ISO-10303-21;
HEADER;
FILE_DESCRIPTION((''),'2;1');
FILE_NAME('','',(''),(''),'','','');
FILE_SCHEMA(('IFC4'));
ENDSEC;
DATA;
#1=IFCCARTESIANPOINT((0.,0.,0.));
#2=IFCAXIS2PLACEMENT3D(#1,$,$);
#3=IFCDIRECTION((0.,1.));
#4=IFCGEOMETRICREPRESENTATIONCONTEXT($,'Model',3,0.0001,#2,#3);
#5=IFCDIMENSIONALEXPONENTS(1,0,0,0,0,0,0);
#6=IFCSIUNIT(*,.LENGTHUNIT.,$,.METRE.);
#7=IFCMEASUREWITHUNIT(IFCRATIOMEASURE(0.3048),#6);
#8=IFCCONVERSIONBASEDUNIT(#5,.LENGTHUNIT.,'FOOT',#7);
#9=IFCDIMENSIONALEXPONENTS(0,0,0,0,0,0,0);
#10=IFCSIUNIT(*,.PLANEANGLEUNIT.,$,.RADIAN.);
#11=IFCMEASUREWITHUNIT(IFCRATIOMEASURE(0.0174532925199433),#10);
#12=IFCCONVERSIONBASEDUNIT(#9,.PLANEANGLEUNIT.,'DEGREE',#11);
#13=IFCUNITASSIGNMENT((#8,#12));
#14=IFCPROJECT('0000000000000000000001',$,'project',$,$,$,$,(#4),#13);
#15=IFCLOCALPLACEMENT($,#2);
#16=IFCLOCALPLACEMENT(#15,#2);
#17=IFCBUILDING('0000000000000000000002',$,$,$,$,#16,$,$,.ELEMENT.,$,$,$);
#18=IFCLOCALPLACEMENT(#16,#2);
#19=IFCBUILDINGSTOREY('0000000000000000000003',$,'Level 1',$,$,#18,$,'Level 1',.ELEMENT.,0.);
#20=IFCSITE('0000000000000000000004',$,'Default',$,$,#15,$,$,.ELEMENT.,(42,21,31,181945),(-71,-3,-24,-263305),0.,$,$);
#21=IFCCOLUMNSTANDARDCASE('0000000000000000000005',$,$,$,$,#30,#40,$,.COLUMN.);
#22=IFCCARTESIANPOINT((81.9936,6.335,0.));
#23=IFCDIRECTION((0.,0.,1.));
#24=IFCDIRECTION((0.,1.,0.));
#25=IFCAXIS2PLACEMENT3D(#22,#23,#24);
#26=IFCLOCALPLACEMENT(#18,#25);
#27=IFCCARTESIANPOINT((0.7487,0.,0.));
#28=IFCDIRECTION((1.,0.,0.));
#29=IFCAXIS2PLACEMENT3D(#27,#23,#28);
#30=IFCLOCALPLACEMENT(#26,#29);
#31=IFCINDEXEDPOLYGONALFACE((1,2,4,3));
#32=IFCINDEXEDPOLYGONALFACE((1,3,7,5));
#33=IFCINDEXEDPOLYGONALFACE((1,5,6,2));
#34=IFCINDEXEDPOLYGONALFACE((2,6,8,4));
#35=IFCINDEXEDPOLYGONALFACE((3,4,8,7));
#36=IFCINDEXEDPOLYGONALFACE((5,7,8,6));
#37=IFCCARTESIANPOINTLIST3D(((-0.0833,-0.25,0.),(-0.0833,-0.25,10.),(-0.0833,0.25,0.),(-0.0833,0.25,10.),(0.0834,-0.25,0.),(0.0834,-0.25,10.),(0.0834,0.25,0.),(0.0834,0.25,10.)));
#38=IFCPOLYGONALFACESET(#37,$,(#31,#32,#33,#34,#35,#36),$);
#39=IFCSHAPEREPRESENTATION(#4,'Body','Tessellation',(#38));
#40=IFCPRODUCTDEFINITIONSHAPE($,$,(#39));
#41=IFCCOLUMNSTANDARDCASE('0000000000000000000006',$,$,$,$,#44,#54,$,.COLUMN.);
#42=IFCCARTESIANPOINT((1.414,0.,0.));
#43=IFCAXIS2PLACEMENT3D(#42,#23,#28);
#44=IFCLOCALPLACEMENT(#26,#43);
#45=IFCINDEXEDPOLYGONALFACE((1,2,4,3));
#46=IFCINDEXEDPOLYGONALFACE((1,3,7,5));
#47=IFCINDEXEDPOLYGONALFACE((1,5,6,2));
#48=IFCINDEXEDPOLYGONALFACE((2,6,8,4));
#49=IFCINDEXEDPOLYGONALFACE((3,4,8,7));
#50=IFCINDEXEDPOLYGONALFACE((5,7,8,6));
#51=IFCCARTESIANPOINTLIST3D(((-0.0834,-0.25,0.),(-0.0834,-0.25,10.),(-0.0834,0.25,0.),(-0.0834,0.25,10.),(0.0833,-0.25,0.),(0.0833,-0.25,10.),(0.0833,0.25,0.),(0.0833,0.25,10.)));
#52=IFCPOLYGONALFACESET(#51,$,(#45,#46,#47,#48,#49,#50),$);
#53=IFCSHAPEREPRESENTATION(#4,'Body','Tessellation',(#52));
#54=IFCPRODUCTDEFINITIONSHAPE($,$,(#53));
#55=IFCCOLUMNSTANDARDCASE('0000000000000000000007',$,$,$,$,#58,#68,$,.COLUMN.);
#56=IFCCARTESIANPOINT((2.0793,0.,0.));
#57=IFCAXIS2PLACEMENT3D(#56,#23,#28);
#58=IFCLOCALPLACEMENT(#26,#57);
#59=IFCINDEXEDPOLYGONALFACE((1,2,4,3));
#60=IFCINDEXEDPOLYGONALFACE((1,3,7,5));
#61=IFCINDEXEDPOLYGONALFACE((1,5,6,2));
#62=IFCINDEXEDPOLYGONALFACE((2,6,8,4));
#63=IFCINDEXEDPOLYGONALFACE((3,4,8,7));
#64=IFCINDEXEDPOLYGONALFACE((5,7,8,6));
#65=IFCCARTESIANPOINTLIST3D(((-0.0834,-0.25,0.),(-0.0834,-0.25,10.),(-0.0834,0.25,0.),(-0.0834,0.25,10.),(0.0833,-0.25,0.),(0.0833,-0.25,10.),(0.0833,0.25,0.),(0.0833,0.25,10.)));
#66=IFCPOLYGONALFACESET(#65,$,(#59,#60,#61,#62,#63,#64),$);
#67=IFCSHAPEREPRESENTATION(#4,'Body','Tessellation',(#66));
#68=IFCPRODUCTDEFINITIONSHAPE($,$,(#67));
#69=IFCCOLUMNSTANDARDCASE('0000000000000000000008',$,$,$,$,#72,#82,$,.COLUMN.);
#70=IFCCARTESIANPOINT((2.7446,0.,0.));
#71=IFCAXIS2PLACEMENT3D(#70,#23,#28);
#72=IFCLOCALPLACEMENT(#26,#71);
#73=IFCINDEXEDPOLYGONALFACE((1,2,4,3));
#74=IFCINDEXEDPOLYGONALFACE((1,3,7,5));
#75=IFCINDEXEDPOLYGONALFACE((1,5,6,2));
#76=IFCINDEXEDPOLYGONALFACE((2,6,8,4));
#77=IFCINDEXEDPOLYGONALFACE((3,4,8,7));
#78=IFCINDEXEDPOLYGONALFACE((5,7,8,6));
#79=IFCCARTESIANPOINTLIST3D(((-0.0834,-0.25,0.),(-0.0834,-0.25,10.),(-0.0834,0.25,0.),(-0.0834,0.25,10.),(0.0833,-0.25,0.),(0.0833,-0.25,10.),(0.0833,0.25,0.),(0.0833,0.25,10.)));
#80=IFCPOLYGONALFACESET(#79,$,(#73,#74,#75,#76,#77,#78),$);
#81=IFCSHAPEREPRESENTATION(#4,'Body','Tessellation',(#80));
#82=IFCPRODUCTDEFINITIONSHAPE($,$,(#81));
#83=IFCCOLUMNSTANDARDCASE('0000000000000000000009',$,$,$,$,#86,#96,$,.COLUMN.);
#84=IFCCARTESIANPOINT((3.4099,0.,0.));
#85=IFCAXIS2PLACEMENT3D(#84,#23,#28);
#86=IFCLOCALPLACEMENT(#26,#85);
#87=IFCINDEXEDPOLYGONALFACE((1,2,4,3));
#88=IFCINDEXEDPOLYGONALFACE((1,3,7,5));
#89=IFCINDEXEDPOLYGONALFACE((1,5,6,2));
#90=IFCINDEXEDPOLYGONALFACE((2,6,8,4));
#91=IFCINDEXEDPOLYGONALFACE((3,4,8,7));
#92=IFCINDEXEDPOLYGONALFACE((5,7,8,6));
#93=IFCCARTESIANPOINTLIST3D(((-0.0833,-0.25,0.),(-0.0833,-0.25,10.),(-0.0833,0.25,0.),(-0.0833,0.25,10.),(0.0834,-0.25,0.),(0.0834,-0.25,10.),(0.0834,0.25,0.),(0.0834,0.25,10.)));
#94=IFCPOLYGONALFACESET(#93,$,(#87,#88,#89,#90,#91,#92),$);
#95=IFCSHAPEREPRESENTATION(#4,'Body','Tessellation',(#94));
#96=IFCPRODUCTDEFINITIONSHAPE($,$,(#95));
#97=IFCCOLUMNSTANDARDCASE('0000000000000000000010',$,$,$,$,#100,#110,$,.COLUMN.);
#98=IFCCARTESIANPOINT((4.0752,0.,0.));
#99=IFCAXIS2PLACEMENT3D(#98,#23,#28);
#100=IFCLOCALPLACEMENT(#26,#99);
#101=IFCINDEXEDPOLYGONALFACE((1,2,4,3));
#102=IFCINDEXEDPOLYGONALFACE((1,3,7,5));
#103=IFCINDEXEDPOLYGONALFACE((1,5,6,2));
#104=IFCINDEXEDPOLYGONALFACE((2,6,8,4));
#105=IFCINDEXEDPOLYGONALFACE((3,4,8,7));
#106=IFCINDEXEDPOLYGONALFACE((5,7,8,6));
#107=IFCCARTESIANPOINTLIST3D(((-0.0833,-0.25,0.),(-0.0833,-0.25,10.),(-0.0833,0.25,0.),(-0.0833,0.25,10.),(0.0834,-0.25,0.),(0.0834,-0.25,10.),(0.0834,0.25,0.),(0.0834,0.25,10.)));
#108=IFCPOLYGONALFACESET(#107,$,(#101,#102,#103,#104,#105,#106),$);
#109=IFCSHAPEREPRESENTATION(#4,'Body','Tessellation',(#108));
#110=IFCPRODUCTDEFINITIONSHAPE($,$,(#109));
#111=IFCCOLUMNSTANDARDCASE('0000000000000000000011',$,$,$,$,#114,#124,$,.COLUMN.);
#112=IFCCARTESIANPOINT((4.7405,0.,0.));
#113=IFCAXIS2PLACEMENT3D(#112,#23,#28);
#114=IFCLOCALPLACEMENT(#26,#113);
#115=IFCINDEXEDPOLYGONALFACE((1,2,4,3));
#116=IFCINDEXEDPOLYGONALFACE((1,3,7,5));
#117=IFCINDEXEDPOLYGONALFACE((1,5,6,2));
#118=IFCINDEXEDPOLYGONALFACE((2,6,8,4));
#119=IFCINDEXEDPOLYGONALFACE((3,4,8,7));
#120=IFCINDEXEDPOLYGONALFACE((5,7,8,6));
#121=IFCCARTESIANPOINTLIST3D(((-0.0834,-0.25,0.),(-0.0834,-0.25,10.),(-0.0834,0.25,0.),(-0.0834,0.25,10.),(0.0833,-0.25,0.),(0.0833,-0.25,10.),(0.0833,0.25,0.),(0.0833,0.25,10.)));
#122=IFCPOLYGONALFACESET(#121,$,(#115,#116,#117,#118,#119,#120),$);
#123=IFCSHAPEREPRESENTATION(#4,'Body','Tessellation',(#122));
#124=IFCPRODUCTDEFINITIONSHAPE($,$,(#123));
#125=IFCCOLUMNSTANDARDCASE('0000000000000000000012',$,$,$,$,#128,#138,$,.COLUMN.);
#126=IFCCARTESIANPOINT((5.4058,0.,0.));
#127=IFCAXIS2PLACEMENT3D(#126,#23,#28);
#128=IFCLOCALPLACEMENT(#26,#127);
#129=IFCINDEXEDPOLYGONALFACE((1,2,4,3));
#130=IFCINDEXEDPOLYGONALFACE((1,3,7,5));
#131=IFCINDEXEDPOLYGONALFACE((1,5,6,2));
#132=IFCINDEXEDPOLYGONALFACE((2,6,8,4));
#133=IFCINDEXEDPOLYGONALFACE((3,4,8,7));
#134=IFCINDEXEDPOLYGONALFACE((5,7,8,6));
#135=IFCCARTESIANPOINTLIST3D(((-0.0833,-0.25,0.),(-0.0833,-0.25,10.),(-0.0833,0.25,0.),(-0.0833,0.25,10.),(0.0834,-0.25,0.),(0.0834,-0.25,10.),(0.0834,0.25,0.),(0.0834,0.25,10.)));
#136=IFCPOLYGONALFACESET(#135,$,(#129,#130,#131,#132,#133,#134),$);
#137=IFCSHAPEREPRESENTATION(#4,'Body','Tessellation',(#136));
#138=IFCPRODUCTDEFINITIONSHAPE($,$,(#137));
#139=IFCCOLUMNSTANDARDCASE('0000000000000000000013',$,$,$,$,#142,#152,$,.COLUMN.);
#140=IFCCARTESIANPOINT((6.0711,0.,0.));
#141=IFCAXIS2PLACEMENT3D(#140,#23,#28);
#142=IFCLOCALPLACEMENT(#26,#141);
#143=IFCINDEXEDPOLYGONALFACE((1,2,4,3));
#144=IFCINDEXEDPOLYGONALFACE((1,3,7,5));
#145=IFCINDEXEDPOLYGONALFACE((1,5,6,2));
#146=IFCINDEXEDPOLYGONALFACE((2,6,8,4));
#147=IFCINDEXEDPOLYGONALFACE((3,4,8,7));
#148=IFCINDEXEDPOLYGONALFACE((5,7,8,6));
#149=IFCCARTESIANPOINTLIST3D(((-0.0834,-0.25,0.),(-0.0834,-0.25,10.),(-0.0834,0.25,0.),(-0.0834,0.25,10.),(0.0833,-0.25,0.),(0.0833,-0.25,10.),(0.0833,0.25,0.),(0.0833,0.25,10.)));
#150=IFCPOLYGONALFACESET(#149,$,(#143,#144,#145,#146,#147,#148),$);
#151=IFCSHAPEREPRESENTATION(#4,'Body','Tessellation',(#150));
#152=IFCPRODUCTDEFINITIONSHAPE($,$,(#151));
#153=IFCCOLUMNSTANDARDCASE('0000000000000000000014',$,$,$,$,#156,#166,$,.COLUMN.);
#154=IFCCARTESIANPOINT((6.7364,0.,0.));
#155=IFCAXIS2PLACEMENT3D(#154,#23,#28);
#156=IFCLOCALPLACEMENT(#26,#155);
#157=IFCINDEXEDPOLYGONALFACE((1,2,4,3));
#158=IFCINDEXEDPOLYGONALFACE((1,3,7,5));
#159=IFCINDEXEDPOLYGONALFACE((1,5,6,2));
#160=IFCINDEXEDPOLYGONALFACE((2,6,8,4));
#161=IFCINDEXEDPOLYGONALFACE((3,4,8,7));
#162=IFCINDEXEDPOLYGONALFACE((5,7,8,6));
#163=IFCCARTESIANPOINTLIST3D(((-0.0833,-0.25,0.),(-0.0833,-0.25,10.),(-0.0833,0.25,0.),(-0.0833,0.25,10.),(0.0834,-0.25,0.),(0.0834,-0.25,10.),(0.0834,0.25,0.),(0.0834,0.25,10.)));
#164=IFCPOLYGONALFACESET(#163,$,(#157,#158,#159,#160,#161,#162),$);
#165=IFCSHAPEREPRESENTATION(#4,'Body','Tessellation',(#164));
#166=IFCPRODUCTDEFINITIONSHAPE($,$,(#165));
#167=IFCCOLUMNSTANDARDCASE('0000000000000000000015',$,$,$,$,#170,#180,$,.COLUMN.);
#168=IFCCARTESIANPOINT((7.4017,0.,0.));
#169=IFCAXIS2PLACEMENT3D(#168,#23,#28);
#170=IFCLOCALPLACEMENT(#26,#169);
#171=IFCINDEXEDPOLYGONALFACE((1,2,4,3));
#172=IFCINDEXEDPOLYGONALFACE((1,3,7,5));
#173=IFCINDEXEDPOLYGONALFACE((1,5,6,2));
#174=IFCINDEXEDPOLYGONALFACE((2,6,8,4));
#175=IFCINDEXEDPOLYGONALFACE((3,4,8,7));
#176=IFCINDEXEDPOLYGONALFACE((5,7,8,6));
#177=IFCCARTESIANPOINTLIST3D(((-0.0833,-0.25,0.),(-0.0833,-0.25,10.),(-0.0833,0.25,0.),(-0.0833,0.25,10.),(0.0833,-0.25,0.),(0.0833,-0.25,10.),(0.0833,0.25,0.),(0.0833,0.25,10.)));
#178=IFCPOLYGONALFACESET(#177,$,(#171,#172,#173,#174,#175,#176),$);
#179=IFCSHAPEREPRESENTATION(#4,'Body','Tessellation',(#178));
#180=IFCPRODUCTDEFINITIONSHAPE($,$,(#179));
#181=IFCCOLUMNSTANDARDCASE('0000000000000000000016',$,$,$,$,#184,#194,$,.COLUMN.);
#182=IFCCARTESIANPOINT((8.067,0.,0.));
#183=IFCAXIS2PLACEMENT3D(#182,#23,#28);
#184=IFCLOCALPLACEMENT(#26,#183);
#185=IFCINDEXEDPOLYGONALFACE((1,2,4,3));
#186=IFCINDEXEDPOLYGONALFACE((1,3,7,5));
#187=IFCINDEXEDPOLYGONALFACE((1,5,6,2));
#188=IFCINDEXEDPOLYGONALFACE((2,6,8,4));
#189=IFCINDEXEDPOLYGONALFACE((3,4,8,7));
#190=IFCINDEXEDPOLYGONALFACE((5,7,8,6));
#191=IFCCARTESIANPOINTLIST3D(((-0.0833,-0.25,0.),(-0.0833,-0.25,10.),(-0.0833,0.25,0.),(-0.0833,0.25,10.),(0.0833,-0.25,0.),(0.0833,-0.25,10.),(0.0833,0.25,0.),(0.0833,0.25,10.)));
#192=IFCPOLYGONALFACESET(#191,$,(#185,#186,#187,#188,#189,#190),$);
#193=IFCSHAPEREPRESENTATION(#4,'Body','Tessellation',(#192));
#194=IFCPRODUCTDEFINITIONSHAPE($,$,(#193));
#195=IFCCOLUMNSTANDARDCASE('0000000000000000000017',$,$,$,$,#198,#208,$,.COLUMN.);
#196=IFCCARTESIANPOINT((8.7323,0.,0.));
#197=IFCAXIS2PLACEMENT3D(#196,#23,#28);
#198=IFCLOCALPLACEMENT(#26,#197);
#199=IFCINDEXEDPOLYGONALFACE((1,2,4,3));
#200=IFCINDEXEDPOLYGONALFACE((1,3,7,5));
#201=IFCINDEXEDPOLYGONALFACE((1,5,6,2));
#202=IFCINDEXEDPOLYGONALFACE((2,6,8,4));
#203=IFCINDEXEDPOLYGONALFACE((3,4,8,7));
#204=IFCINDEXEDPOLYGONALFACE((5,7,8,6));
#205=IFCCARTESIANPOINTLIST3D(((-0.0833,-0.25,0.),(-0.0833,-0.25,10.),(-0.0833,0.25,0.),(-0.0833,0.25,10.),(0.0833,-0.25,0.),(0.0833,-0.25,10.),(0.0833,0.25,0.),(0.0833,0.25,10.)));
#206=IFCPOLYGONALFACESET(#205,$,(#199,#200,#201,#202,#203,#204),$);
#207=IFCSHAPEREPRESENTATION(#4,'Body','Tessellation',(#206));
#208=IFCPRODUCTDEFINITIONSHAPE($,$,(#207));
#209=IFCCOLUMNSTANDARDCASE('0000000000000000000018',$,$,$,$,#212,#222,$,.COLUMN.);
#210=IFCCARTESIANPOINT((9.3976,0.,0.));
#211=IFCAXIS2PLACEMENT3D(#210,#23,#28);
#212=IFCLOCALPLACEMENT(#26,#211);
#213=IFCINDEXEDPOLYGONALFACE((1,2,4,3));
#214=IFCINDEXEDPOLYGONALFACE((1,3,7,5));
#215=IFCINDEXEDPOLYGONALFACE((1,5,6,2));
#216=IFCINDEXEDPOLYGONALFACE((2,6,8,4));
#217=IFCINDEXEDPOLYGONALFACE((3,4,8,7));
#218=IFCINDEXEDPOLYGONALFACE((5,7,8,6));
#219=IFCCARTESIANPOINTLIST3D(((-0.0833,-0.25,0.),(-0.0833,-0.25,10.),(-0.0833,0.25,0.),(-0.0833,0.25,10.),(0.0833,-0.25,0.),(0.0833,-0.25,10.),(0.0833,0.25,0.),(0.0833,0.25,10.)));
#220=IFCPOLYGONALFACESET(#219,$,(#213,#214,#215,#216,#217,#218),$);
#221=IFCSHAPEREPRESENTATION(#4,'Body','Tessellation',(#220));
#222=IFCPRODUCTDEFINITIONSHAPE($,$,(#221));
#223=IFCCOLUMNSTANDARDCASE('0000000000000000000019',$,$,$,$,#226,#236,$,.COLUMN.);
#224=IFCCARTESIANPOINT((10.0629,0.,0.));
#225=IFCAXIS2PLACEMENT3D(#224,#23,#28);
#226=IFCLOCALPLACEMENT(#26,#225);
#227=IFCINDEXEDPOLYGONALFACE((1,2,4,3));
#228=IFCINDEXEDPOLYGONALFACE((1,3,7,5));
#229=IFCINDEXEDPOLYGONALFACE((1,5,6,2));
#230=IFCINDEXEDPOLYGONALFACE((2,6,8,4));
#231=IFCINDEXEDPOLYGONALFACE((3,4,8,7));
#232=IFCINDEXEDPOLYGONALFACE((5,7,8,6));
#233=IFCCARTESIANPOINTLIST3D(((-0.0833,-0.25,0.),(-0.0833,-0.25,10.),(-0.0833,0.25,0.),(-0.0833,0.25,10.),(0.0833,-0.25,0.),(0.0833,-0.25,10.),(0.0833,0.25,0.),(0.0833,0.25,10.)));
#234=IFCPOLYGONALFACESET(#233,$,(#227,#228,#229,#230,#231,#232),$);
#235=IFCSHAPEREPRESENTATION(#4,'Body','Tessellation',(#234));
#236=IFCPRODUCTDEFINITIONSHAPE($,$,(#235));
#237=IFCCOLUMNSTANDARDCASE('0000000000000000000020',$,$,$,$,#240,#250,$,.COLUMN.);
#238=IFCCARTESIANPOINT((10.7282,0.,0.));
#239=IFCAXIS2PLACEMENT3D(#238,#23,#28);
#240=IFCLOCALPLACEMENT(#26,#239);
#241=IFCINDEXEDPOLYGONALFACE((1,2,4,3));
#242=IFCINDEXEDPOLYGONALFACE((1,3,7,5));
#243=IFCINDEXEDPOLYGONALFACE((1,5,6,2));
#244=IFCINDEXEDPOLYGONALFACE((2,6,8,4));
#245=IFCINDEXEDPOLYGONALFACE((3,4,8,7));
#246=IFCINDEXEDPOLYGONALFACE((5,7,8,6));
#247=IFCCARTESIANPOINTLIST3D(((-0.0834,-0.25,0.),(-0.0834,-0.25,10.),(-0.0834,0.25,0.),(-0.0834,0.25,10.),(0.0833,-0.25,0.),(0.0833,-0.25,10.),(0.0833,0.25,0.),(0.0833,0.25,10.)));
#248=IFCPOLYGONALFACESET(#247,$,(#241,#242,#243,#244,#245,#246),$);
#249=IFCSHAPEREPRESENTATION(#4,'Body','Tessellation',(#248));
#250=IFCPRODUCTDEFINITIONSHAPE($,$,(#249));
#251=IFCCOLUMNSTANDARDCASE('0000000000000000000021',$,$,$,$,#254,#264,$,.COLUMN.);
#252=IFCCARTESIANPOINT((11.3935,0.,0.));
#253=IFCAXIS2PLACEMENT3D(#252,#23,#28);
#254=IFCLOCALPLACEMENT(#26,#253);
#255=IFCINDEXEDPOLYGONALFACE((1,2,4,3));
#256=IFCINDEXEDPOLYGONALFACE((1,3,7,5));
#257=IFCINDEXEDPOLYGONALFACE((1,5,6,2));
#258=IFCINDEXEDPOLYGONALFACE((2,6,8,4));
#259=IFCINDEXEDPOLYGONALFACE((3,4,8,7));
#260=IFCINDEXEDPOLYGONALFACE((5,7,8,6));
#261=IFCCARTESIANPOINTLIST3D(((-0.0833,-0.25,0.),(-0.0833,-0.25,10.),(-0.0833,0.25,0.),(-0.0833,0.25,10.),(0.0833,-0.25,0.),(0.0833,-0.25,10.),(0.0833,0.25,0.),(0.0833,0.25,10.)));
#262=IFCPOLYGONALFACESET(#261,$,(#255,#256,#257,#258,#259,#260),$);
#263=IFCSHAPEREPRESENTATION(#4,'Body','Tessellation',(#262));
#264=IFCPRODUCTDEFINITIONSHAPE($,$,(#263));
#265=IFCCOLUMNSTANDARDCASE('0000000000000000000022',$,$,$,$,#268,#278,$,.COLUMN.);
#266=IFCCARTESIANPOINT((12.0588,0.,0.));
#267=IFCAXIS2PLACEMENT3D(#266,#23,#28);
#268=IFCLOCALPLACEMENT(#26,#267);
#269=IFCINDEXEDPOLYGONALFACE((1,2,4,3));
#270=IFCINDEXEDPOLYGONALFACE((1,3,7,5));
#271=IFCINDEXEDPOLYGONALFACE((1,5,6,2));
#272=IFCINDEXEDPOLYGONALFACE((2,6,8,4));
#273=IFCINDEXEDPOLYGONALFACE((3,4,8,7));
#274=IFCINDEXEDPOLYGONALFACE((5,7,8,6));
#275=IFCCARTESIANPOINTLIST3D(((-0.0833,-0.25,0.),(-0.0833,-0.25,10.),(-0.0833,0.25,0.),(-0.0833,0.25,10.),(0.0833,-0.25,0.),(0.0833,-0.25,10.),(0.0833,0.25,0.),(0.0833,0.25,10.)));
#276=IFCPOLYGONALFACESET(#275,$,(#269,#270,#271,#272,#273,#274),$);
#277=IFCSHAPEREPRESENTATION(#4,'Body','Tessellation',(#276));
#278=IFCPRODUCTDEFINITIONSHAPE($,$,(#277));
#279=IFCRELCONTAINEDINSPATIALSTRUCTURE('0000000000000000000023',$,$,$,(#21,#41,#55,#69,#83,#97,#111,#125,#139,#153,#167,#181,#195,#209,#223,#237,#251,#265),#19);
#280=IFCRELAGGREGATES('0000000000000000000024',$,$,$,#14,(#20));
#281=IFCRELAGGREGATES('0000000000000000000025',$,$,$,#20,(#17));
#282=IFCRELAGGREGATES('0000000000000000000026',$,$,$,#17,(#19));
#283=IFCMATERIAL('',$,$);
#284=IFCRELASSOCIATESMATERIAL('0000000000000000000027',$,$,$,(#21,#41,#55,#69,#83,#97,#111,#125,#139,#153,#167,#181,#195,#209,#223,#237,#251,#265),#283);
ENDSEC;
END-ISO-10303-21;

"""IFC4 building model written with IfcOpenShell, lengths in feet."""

from ifc_helpers import new_model, entity, si_unit, converted_unit, direction, frame, origin, place, context, project, spatial, rectangle, extrude, material, element, save


model = new_model("IFC4")

# Units and contexts
model_context = context("Model", 3, precision=0.0001, world=origin(), true_north=direction((0.0, 1.0)))
ifc_project = project(units=[converted_unit("LENGTHUNIT", "FOOT", entity("IfcRatioMeasure", 0.3048), si_unit("LENGTHUNIT", "METRE"), dimensions=[1, 0, 0, 0, 0, 0, 0]), converted_unit("PLANEANGLEUNIT", "DEGREE", entity("IfcRatioMeasure", 0.0174532925199433), si_unit("PLANEANGLEUNIT", "RADIAN"), dimensions=[0, 0, 0, 0, 0, 0, 0])], contexts=[model_context])

# Site, building, storey
site_placement = place(None, origin())
site = spatial("IfcSite", under=ifc_project, at=site_placement, Name="Default", CompositionType="ELEMENT", RefLatitude=(42, 21, 31, 181945), RefLongitude=(-71, -3, -24, -263305), RefElevation=0.0)
building_placement = place(site_placement, origin())
building = spatial("IfcBuilding", under=site, at=building_placement, CompositionType="ELEMENT")
storey_placement = place(building_placement, origin())
storey = spatial("IfcBuildingStorey", under=building, at=storey_placement, Name="Level 1", LongName="Level 1", CompositionType="ELEMENT", Elevation=0.0)

# Columns
ifc_material_1 = material(Name="")
wall_placement = place(storey_placement, frame((81.9936, 6.335, 0.0), z_axis=(0.0, 0.0, 1.0), x_axis=(0.0, 1.0, 0.0)))
for number, where, z_axis, x_axis in (
    (1, (0.7487, 0.0, 0.0), (0.0, 0.0, 1.0), (1.0, 0.0, 0.0)),
    (2, (1.414, 0.0, 0.0), (0.0, 0.0, 1.0), (1.0, 0.0, 0.0)),
    (3, (2.0793, 0.0, 0.0), (0.0, 0.0, 1.0), (1.0, 0.0, 0.0)),
    (4, (2.7446, 0.0, 0.0), (0.0, 0.0, 1.0), (1.0, 0.0, 0.0)),
    (5, (3.4099, 0.0, 0.0), (0.0, 0.0, 1.0), (1.0, 0.0, 0.0)),
    (6, (4.0752, 0.0, 0.0), (0.0, 0.0, 1.0), (1.0, 0.0, 0.0)),
    (7, (4.7405, 0.0, 0.0), (0.0, 0.0, 1.0), (1.0, 0.0, 0.0)),
    (8, (5.4058, 0.0, 0.0), (0.0, 0.0, 1.0), (1.0, 0.0, 0.0)),
    (9, (6.0711, 0.0, 0.0), (0.0, 0.0, 1.0), (1.0, 0.0, 0.0)),
    (10, (6.7364, 0.0, 0.0), (0.0, 0.0, 1.0), (1.0, 0.0, 0.0)),
    (11, (7.4017, 0.0, 0.0), (0.0, 0.0, 1.0), (1.0, 0.0, 0.0)),
    (12, (8.067, 0.0, 0.0), (0.0, 0.0, 1.0), (1.0, 0.0, 0.0)),
    (13, (8.7323, 0.0, 0.0), (0.0, 0.0, 1.0), (1.0, 0.0, 0.0)),
    (14, (9.3976, 0.0, 0.0), (0.0, 0.0, 1.0), (1.0, 0.0, 0.0)),
    (15, (10.0629, 0.0, 0.0), (0.0, 0.0, 1.0), (1.0, 0.0, 0.0)),
    (16, (10.7282, 0.0, 0.0), (0.0, 0.0, 1.0), (1.0, 0.0, 0.0)),
    (17, (11.3935, 0.0, 0.0), (0.0, 0.0, 1.0), (1.0, 0.0, 0.0)),
    (18, (12.0588, 0.0, 0.0), (0.0, 0.0, 1.0), (1.0, 0.0, 0.0)),
):
    element("IfcColumnStandardCase", number, at=place(wall_placement, frame(where, z_axis=z_axis, x_axis=x_axis)), inside=storey, material=ifc_material_1, PredefinedType="COLUMN", context=model_context, shape_type="SweptSolid", body=[
        extrude(rectangle(XDim=0.1667, YDim=0.5), origin(), (0.0, 0.0, 1.0), 10.0),
    ])

save(model, "model.ifc")
